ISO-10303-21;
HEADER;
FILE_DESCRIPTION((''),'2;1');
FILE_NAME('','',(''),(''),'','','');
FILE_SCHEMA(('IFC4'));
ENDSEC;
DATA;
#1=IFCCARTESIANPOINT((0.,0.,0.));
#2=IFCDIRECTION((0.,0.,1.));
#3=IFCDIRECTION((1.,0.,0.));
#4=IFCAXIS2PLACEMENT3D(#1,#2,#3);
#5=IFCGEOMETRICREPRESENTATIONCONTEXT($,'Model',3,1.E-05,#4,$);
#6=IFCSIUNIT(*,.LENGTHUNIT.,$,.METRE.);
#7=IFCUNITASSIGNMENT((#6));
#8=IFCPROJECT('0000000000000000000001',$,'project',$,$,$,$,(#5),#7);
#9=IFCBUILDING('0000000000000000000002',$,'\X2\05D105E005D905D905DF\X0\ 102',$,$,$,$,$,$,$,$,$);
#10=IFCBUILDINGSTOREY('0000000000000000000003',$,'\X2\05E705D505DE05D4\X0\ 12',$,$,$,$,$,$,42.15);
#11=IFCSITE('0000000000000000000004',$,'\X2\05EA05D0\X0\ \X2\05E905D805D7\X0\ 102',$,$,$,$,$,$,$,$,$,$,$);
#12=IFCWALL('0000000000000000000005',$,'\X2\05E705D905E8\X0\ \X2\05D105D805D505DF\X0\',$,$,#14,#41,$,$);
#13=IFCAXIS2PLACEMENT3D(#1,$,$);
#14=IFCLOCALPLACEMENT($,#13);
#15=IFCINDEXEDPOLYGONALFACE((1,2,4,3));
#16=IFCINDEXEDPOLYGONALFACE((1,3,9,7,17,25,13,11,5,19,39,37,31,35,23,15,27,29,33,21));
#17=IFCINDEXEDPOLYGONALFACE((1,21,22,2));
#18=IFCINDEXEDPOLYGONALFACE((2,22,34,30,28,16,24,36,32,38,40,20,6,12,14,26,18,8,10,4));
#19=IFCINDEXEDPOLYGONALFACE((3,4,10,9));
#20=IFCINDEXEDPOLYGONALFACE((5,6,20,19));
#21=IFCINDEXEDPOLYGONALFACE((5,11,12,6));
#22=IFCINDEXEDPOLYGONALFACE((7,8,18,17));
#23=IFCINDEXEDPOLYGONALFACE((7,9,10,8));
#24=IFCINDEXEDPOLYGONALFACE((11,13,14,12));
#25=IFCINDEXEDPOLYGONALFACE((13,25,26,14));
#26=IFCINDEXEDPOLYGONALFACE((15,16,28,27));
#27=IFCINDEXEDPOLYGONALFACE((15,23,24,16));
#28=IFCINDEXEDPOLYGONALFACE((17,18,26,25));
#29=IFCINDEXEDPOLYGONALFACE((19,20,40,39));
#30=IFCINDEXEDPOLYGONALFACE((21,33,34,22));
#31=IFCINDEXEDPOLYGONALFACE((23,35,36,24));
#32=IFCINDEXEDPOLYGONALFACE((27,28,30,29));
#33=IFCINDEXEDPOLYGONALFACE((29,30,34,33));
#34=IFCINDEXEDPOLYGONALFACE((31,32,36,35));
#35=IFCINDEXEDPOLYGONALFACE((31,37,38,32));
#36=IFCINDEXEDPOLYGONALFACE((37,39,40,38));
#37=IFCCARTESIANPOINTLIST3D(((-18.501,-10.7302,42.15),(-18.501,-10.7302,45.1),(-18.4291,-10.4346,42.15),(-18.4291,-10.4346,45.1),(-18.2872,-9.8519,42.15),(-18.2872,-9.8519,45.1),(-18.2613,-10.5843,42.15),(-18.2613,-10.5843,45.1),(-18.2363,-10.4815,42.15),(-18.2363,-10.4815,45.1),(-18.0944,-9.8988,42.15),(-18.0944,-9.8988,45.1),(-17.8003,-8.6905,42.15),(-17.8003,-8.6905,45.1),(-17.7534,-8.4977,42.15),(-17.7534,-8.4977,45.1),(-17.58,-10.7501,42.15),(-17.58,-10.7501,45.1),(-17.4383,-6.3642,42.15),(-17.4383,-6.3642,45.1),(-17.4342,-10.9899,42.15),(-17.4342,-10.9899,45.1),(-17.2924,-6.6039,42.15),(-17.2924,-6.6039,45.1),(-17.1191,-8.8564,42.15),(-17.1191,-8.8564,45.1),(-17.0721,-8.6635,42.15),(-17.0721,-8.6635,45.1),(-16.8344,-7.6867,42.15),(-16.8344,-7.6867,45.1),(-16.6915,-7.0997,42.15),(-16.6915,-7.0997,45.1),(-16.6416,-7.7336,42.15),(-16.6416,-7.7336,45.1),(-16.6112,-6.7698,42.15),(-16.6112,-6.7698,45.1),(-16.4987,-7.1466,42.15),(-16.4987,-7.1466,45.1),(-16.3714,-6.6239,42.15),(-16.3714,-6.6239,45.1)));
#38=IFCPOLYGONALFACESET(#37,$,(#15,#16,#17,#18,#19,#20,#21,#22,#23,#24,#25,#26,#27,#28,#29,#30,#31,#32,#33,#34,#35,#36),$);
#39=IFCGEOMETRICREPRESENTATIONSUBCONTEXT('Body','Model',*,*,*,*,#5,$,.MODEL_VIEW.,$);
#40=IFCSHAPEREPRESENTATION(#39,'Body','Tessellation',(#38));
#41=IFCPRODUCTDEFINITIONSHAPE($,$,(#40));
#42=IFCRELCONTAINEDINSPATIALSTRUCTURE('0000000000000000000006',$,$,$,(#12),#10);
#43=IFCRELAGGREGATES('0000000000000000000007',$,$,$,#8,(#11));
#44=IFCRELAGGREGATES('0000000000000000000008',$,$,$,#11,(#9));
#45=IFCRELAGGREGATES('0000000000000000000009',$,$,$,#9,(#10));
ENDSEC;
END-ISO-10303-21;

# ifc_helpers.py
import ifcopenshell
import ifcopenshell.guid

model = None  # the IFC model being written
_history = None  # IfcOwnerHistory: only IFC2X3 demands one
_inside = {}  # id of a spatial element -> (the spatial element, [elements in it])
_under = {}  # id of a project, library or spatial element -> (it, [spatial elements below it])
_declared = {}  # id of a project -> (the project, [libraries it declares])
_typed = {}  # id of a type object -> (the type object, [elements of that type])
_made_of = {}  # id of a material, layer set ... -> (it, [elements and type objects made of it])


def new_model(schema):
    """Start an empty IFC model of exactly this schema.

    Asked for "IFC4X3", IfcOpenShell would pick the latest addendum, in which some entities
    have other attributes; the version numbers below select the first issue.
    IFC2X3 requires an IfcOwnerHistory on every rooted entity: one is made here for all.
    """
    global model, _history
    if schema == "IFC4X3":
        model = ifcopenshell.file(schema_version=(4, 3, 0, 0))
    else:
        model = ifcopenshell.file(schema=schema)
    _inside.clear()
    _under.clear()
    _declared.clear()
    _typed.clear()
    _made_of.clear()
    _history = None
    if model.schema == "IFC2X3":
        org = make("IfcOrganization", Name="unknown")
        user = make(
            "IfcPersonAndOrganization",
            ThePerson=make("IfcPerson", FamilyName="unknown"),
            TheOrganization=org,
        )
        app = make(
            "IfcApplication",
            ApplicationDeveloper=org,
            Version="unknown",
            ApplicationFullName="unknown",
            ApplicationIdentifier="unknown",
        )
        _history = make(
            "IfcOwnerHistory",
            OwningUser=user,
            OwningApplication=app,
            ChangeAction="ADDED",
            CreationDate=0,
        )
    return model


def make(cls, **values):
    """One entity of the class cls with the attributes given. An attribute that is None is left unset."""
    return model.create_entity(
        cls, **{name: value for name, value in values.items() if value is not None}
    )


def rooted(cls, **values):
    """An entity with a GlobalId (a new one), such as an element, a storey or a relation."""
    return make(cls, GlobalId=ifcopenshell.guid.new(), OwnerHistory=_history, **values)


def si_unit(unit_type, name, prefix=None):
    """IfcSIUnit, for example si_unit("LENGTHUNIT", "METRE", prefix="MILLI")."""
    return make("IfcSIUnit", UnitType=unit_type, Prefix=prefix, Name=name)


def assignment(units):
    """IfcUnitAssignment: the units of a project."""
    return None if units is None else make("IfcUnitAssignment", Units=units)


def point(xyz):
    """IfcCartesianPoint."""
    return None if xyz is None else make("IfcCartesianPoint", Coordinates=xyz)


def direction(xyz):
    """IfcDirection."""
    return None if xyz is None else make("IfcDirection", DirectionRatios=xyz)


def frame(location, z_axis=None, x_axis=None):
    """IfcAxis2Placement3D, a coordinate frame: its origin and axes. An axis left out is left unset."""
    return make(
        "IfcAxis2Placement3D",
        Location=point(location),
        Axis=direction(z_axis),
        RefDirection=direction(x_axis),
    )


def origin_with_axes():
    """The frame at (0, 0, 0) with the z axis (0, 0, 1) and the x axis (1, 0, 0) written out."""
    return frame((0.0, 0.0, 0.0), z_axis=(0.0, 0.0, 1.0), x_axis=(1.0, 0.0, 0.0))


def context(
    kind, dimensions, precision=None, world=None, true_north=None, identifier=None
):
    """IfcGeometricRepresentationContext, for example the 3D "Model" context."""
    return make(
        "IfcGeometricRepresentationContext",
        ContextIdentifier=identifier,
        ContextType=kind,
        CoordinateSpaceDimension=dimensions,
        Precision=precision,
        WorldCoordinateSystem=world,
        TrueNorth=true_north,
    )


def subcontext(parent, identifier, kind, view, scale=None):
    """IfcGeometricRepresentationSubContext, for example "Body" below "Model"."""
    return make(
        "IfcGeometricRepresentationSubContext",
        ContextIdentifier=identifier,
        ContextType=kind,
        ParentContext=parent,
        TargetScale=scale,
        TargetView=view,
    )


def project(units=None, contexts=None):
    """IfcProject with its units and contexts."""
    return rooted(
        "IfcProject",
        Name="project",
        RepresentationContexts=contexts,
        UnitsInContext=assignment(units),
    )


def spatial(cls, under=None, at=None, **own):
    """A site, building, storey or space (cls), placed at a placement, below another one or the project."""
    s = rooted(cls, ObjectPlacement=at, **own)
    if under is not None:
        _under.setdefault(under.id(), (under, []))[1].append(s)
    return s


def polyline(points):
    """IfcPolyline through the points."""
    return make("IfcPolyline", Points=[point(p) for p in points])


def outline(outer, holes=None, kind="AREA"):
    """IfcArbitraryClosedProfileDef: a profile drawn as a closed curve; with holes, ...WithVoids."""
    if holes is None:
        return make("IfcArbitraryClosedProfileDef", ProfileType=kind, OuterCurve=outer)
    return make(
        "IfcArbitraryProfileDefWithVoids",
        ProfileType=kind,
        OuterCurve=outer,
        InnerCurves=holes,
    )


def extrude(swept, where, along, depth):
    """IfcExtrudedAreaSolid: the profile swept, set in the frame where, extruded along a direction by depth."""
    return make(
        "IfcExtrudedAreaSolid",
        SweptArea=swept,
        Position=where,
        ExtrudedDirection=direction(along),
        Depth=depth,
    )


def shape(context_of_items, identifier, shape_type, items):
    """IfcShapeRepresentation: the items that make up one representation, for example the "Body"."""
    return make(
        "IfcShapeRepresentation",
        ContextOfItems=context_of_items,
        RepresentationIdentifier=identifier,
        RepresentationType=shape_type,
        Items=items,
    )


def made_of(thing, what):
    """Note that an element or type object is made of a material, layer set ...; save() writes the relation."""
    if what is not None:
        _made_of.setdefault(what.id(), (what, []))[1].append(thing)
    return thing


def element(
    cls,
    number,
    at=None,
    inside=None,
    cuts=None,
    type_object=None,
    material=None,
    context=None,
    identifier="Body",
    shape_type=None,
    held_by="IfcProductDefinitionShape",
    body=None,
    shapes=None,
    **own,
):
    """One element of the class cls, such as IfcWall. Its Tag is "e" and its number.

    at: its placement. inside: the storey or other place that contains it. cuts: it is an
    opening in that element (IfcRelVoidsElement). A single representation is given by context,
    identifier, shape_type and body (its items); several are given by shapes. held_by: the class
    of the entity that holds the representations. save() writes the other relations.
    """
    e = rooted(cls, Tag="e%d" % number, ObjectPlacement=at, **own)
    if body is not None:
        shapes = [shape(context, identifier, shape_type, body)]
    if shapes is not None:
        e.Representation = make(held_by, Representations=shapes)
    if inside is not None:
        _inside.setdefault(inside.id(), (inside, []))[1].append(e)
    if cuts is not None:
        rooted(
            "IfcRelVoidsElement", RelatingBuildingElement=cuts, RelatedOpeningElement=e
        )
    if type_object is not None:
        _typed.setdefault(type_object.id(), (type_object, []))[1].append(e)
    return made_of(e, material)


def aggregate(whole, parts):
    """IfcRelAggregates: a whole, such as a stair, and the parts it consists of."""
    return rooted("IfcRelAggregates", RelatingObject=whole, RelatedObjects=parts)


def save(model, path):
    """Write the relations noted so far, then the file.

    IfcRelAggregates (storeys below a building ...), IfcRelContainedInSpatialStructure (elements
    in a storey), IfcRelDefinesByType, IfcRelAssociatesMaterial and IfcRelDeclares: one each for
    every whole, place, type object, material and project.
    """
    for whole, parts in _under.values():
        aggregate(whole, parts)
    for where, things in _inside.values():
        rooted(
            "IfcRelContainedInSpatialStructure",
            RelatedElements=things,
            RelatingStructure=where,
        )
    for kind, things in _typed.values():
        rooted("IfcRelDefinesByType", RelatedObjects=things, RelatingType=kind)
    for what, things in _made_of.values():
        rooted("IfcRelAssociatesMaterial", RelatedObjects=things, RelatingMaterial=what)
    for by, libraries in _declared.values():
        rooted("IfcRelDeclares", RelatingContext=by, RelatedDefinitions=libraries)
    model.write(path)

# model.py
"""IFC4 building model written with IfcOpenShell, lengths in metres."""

from ifc_helpers import new_model, si_unit, frame, origin_with_axes, context, subcontext, project, spatial, polyline, outline, extrude, element, save


model = new_model("IFC4")

# Units and contexts
model_context = context("Model", 3, precision=1e-05, world=origin_with_axes())
body_context = subcontext(model_context, "Body", "Model", "MODEL_VIEW")
ifc_project = project(units=[si_unit("LENGTHUNIT", "METRE")], contexts=[model_context])

# Site, building, storey
site = spatial("IfcSite", under=ifc_project, Name="תא שטח 102")
building = spatial("IfcBuilding", under=site, Name="בניין 102")
storey = spatial("IfcBuildingStorey", under=building, Name="קומה 12", Elevation=42.15)

# Wall
element("IfcWall", 1, inside=storey, Name="קיר בטון", context=body_context, shape_type="SweptSolid", body=[
    extrude(outline(polyline([(-18.4291, -10.4346), (-18.501, -10.7302), (-17.4342, -10.9899), (-16.6416, -7.7336), (-16.8344, -7.6867), (-17.0721, -8.6635), (-17.7534, -8.4977), (-17.2924, -6.6039), (-16.6112, -6.7698), (-16.6915, -7.0997), (-16.4987, -7.1466), (-16.3714, -6.6239), (-17.4383, -6.3642), (-18.2872, -9.8519), (-18.0944, -9.8988), (-17.8003, -8.6905), (-17.1191, -8.8564), (-17.58, -10.7501), (-18.2613, -10.5843), (-18.2363, -10.4815), (-18.4291, -10.4346)])), frame((0.0, 0.0, 42.15)), (0.0, 0.0, 1.0), 2.95),
])

save(model, "model.ifc")
